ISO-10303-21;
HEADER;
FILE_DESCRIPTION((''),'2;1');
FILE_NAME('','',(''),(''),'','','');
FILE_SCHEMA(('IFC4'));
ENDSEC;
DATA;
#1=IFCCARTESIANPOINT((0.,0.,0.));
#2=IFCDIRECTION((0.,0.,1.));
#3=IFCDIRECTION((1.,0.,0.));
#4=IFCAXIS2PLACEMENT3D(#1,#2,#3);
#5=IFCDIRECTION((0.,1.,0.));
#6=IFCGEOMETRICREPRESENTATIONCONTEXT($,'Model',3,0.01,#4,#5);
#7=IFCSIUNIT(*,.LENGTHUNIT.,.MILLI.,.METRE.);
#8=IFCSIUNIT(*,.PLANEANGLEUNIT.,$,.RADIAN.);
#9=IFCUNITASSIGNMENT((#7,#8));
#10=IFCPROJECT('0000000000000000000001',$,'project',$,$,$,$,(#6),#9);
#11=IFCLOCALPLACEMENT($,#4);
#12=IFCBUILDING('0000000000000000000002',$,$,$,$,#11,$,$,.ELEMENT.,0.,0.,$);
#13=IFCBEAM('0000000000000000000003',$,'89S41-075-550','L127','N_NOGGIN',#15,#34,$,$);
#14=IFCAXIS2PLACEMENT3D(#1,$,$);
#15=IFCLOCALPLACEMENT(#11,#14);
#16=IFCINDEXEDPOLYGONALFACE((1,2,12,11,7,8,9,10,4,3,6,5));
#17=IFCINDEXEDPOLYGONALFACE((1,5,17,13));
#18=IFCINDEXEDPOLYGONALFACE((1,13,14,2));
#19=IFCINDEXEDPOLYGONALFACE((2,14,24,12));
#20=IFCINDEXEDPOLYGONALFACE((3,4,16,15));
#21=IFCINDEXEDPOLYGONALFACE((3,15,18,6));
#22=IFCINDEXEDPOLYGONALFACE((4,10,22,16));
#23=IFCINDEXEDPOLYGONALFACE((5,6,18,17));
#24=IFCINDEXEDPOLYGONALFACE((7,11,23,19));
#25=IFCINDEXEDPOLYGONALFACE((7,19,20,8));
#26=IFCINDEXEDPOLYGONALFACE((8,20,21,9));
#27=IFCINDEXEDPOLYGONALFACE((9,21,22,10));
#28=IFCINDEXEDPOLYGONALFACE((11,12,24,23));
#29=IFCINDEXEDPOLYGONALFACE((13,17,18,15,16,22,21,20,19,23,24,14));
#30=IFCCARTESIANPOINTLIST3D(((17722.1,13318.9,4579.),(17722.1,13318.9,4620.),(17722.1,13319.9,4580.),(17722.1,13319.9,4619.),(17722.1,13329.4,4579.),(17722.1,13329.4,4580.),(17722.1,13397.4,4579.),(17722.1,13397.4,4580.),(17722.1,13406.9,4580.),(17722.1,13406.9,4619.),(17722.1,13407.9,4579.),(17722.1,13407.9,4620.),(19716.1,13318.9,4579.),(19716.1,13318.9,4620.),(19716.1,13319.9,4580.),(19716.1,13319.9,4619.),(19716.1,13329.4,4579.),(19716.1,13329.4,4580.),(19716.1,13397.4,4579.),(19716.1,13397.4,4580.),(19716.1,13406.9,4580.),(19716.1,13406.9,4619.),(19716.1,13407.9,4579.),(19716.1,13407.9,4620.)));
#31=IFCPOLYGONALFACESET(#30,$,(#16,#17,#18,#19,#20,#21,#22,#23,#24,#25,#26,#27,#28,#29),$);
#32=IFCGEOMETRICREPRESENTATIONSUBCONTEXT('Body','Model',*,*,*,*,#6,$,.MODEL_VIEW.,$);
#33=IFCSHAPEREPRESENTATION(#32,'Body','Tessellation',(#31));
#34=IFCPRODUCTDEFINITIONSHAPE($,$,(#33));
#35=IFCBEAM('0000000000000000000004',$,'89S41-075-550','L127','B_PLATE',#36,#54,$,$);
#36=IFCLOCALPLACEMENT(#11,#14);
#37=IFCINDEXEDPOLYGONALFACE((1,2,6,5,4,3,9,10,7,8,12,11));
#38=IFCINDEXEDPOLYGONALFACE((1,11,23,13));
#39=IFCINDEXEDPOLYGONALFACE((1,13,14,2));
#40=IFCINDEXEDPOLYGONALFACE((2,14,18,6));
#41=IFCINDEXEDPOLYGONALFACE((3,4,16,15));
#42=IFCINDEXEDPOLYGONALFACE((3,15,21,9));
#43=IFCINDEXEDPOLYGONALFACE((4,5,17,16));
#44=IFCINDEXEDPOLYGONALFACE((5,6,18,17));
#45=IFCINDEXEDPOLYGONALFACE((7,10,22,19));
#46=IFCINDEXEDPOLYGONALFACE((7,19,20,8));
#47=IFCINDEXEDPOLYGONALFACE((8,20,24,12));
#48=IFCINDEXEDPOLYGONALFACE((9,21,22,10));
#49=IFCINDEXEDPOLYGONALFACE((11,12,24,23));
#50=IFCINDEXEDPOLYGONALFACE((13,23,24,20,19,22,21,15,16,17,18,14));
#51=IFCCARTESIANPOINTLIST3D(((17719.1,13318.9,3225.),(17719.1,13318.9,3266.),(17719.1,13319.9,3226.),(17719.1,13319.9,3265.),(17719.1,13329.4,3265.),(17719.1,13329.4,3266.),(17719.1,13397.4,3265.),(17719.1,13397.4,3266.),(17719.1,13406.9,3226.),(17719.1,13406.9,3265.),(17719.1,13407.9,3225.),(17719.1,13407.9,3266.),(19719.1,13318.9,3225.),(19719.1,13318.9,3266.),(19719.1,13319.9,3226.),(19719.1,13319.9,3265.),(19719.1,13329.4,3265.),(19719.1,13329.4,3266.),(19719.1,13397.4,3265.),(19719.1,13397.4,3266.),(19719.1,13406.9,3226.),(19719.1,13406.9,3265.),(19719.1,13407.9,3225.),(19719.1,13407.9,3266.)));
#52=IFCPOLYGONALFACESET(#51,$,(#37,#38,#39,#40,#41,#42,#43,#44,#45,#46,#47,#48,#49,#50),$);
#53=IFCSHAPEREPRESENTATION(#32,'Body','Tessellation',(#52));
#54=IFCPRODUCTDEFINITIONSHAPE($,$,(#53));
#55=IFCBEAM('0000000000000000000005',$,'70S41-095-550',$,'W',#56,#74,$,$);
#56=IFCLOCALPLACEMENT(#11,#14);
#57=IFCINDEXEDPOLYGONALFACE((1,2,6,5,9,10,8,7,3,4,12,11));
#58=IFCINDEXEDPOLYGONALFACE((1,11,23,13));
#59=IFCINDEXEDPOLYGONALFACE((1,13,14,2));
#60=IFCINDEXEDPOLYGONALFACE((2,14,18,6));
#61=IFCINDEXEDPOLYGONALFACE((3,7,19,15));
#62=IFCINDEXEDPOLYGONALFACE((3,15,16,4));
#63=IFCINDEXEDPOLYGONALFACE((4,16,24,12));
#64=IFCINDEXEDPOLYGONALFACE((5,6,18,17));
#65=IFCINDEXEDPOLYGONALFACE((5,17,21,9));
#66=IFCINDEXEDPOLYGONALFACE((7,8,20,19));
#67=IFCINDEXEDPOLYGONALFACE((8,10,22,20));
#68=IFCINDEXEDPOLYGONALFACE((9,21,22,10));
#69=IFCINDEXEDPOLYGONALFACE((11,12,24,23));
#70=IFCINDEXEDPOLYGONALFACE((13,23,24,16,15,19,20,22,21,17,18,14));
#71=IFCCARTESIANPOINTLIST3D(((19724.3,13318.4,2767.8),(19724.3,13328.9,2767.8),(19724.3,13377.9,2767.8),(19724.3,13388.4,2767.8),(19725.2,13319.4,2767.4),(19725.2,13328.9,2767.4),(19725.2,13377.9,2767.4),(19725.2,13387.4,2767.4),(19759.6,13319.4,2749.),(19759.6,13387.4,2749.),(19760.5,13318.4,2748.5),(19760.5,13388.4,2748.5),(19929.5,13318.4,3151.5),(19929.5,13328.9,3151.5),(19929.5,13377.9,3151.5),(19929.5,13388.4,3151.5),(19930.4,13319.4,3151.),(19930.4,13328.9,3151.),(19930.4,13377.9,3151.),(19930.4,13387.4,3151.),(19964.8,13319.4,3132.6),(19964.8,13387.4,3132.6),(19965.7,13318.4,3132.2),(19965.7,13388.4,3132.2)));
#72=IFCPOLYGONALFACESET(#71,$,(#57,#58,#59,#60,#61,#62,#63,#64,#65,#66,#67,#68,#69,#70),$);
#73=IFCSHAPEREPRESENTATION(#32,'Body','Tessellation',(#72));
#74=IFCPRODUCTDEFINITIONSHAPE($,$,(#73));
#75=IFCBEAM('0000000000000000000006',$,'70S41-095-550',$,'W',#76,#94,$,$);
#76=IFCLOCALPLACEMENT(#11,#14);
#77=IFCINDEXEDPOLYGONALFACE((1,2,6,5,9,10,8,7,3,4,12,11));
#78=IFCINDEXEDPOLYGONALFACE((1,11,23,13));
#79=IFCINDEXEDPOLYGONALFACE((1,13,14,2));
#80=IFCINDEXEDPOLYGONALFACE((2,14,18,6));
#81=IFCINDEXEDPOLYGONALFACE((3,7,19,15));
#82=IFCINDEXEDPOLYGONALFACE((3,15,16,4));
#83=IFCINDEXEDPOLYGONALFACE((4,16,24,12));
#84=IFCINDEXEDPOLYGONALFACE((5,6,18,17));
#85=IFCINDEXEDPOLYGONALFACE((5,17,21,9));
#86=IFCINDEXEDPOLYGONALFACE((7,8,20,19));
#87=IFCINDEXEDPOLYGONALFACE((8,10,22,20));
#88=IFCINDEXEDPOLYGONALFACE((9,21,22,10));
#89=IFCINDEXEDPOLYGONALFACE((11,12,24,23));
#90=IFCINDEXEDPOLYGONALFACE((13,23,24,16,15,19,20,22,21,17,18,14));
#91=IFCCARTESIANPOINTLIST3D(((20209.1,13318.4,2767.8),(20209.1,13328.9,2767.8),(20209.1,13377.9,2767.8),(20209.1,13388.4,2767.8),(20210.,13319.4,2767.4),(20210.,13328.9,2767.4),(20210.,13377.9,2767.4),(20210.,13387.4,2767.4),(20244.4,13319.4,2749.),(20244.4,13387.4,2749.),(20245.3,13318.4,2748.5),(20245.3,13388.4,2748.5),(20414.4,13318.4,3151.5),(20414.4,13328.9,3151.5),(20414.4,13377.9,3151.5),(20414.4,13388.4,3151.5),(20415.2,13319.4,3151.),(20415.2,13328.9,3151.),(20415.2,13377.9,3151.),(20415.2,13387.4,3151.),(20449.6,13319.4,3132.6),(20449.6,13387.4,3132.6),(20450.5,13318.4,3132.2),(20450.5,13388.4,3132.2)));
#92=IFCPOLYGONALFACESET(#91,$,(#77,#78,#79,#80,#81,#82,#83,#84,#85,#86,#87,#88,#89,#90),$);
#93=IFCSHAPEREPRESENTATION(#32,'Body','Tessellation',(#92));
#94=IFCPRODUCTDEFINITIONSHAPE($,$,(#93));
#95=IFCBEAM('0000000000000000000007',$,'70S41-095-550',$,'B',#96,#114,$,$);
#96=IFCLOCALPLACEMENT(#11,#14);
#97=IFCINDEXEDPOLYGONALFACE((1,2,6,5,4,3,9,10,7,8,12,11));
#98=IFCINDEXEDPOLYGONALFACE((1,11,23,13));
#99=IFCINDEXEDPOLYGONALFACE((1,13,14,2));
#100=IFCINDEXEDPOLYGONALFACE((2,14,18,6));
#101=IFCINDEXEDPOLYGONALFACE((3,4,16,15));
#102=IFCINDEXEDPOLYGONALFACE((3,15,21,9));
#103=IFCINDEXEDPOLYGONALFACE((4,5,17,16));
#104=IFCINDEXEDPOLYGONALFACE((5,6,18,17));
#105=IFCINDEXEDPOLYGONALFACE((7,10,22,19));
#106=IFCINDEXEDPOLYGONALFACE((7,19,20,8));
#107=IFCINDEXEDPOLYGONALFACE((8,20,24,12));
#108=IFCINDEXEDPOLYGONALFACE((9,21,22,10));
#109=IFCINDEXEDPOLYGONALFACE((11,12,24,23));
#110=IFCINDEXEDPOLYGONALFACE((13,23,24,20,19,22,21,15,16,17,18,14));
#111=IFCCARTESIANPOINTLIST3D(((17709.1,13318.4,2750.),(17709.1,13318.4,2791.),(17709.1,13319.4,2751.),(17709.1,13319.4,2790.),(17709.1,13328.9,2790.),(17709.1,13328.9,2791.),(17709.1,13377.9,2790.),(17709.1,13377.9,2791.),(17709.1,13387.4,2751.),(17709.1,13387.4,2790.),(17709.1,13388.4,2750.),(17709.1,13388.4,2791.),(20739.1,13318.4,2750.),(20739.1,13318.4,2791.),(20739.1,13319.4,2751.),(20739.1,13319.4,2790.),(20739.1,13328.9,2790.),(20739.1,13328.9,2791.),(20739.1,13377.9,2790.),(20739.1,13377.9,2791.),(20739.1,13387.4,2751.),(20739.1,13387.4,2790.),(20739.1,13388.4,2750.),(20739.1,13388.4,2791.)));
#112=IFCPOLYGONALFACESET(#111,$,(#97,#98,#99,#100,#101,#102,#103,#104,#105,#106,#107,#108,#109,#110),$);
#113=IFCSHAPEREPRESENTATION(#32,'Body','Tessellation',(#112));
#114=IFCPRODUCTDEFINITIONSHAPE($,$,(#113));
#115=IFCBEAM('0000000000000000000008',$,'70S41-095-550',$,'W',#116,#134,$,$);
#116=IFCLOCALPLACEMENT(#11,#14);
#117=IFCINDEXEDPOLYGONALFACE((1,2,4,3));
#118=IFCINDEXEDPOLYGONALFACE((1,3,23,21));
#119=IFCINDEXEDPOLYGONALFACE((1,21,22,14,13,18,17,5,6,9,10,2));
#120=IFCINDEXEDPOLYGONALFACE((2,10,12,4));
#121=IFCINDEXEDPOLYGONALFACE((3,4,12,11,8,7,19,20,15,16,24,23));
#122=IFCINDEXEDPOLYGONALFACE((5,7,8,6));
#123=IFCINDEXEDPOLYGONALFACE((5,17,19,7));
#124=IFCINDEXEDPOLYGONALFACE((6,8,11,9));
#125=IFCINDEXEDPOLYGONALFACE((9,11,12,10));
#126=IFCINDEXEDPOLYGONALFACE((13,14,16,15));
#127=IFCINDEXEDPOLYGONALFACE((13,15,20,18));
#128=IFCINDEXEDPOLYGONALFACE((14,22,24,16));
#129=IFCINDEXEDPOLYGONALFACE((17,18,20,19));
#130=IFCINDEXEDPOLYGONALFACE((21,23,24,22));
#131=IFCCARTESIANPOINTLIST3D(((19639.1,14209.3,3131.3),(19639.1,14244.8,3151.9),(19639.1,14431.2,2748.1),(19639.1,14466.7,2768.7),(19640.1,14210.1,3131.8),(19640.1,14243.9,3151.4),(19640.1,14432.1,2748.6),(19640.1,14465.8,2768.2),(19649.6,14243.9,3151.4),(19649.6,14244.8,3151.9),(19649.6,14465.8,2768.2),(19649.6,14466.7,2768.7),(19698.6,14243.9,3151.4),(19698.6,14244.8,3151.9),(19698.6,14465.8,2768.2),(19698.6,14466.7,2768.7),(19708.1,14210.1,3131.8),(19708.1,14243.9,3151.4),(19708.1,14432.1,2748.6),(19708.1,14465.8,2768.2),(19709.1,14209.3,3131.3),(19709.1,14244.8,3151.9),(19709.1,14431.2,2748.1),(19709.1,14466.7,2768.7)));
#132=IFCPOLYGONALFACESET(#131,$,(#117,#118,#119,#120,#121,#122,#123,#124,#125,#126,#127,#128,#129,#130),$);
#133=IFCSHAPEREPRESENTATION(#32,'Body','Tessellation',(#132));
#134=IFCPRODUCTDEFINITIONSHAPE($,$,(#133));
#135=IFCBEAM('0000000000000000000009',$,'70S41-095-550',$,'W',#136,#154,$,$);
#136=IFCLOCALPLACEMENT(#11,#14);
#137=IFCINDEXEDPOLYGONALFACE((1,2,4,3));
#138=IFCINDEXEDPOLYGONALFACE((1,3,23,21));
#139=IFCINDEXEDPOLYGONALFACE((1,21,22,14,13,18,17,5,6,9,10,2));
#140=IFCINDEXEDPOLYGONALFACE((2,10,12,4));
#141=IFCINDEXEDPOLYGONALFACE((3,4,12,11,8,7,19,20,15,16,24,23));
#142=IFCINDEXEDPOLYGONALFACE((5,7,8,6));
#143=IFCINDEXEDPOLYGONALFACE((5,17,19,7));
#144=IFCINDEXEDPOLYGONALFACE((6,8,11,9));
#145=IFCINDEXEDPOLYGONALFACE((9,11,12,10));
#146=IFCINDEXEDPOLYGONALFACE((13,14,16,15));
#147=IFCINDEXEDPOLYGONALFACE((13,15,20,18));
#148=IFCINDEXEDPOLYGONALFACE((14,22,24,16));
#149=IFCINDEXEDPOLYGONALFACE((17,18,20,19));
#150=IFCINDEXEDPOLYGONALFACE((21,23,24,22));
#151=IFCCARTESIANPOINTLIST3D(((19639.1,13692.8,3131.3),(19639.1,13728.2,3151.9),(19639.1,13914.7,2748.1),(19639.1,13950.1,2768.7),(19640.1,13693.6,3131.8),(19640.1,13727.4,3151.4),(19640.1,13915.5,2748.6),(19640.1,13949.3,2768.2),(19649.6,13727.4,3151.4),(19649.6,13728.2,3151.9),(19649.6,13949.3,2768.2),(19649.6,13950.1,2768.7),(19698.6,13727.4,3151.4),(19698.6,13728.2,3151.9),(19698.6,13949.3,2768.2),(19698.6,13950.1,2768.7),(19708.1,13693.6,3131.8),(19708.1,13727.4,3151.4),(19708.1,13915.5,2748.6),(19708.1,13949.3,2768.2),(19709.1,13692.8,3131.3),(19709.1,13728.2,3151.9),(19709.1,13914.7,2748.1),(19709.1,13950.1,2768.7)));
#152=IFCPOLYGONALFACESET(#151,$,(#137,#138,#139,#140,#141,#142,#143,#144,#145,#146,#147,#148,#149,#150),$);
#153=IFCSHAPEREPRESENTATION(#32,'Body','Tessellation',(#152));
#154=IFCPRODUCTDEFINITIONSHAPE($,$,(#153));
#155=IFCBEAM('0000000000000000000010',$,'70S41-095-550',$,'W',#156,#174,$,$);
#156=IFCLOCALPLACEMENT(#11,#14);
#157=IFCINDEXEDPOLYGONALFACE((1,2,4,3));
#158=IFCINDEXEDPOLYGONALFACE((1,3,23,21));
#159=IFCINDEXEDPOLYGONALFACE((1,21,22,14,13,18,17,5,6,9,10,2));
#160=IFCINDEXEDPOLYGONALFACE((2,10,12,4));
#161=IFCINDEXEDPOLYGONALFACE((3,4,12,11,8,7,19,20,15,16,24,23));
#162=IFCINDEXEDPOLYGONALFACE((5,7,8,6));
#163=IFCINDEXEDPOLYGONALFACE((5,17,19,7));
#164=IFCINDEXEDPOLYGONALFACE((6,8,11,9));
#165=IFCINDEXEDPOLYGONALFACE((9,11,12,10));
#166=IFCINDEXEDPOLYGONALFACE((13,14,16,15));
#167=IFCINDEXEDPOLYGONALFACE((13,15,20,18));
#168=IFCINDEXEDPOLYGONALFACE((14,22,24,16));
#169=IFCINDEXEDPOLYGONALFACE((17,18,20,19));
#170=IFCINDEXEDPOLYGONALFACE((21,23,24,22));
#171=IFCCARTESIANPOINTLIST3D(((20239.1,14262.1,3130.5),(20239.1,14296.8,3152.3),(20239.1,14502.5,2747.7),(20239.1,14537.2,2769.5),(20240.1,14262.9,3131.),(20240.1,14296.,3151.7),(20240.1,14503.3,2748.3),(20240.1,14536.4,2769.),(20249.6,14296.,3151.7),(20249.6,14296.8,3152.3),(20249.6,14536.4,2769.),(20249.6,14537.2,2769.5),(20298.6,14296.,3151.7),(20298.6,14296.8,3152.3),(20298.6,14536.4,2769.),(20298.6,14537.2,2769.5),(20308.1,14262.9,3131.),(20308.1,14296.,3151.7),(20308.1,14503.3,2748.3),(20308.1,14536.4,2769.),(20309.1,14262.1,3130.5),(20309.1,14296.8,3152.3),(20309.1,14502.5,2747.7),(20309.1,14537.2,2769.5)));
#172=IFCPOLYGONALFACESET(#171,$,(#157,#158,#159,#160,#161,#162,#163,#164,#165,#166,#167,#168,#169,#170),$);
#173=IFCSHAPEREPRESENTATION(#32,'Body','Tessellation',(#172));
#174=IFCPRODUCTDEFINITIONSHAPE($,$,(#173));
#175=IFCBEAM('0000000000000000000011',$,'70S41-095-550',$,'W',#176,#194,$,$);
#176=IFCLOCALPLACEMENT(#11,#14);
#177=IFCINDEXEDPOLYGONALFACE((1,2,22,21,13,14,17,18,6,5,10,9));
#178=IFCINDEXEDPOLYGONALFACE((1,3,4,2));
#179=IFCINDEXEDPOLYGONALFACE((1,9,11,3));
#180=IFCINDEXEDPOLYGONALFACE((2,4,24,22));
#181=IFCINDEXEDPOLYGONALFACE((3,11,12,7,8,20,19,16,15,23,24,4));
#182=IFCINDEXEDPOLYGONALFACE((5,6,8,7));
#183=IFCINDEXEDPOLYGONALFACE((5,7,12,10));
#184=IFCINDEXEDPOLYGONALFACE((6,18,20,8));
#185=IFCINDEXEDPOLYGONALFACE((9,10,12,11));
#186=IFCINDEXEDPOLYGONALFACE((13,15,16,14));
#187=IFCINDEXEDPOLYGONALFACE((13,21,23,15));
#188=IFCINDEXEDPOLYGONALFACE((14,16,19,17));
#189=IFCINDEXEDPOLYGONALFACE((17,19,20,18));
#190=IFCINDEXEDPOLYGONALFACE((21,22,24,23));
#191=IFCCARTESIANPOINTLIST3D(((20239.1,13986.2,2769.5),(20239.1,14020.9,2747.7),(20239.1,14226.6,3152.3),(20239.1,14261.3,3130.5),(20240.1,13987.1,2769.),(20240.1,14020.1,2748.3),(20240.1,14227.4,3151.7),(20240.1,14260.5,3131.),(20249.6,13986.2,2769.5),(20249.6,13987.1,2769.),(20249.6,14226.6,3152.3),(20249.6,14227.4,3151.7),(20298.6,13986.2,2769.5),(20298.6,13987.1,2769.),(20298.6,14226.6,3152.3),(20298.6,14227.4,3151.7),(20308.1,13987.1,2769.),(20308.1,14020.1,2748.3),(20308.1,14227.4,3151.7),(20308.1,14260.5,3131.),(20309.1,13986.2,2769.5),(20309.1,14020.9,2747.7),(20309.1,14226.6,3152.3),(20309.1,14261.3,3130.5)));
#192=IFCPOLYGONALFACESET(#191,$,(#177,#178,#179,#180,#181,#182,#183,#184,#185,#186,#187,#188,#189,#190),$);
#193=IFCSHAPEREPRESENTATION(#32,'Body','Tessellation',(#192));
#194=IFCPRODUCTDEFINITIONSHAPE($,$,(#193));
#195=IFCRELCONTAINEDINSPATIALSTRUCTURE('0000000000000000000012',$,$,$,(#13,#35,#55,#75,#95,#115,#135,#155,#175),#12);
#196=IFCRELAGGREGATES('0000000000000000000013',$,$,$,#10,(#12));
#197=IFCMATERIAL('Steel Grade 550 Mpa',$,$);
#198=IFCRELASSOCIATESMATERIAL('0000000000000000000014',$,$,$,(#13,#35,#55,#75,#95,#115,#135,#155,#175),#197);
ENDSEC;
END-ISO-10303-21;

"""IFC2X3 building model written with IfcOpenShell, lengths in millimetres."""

from ifc_helpers import new_model, si_unit, direction, frame, origin, origin_with_axes, origin_2d_with_axis, place, context, subcontext, project, spatial, c_section, extrude, source, transform, mapped, material, element, save


model = new_model("IFC2X3")

# Units and contexts
model_context = context("Model", 3, precision=0.01, world=origin_with_axes(), true_north=direction((0.0, 1.0, 0.0)))
body_context = subcontext(model_context, "Body", "Model", "MODEL_VIEW")
ifc_project = project(units=[si_unit("LENGTHUNIT", "METRE", prefix="MILLI"), si_unit("PLANEANGLEUNIT", "RADIAN")], contexts=[model_context])

# Building
building_placement = place(None, origin_with_axes())
building = spatial("IfcBuilding", under=ifc_project, at=building_placement, CompositionType="ELEMENT", ElevationOfRefHeight=0.0, ElevationOfTerrain=0.0)

# Shared definitions
ifc_material = material(Name="Steel Grade 550 Mpa")

# Beams
shared_shape_1 = source(origin(), body_context, "Body", "SweptSolid", [
    extrude(c_section(Depth=89.0, Width=41.0, WallThickness=1.0, Girth=10.5, at=origin_2d_with_axis()), origin_with_axes(), (0.0, 0.0, 1.0), 1994.0),
])
beam_1_placement = place(None, frame((19716.1, 13363.4, 4599.5), z_axis=(-1.0, 0.0, 0.0), x_axis=(0.0, 0.0, -1.0)))
element("IfcBeam", 1, at=beam_1_placement, inside=building, material=ifc_material, Name="89S41-075-550", Description="L127", ObjectType="N_NOGGIN", context=body_context, shape_type="MappedRepresentation", body=[
    mapped(shared_shape_1, transform((0.0, 0.0, 0.0), scale=1.0)),
])
shared_shape_2 = source(origin(), body_context, "Body", "SweptSolid", [
    extrude(c_section(Depth=89.0, Width=41.0, WallThickness=1.0, Girth=10.5, at=origin_2d_with_axis()), origin_with_axes(), (0.0, 0.0, 1.0), 2000.0),
])
beam_2_placement = place(None, frame((19719.1, 13363.4, 3245.5), z_axis=(-1.0, 0.0, 0.0), x_axis=(0.0, 0.0, 1.0)))
element("IfcBeam", 2, at=beam_2_placement, inside=building, material=ifc_material, Name="89S41-075-550", Description="L127", ObjectType="B_PLATE", context=body_context, shape_type="MappedRepresentation", body=[
    mapped(shared_shape_2, transform((0.0, 0.0, 0.0), scale=1.0)),
])
shared_shape_3 = source(origin(), body_context, "Body", "SweptSolid", [
    extrude(c_section(Depth=70.0, Width=41.0, WallThickness=1.0, Girth=10.5, at=origin_2d_with_axis()), origin_with_axes(), (0.0, 0.0, 1.0), 435.1),
])
beam_3_placement = place(None, frame((19947.6, 13353.4, 3141.8), z_axis=(-0.471634, 0.0, -0.881794), x_axis=(-0.881794, 0.0, 0.471634)))
element("IfcBeam", 3, at=beam_3_placement, inside=building, material=ifc_material, Name="70S41-095-550", ObjectType="W", context=body_context, shape_type="MappedRepresentation", body=[
    mapped(shared_shape_3, transform((0.0, 0.0, 0.0), scale=1.0)),
])
shared_shape_4 = source(origin(), body_context, "Body", "SweptSolid", [
    extrude(c_section(Depth=70.0, Width=41.0, WallThickness=1.0, Girth=10.5, at=origin_2d_with_axis()), origin_with_axes(), (0.0, 0.0, 1.0), 435.1),
])
beam_4_placement = place(None, frame((20432.4, 13353.4, 3141.8), z_axis=(-0.471634, 0.0, -0.881794), x_axis=(-0.881794, 0.0, 0.471634)))
element("IfcBeam", 4, at=beam_4_placement, inside=building, material=ifc_material, Name="70S41-095-550", ObjectType="W", context=body_context, shape_type="MappedRepresentation", body=[
    mapped(shared_shape_4, transform((0.0, 0.0, 0.0), scale=1.0)),
])
shared_shape_5 = source(origin(), body_context, "Body", "SweptSolid", [
    extrude(c_section(Depth=70.0, Width=41.0, WallThickness=1.0, Girth=10.5, at=origin_2d_with_axis()), origin_with_axes(), (0.0, 0.0, 1.0), 3030.0),
])
beam_5_placement = place(None, frame((20739.1, 13353.4, 2770.5), z_axis=(-1.0, 0.0, 0.0), x_axis=(0.0, 0.0, 1.0)))
element("IfcBeam", 5, at=beam_5_placement, inside=building, material=ifc_material, Name="70S41-095-550", ObjectType="B", context=body_context, shape_type="MappedRepresentation", body=[
    mapped(shared_shape_5, transform((0.0, 0.0, 0.0), scale=1.0)),
])
shared_shape_6 = source(origin(), body_context, "Body", "SweptSolid", [
    extrude(c_section(Depth=70.0, Width=41.0, WallThickness=1.0, Girth=10.5, at=origin_2d_with_axis()), origin_with_axes(), (0.0, 0.0, 1.0), 442.8),
])
beam_6_placement = place(None, frame((19674.1, 14227.0, 3141.6), z_axis=(0.0, 0.501095, -0.865392), x_axis=(0.0, 0.865392, 0.501095)))
element("IfcBeam", 6, at=beam_6_placement, inside=building, material=ifc_material, Name="70S41-095-550", ObjectType="W", context=body_context, shape_type="MappedRepresentation", body=[
    mapped(shared_shape_6, transform((0.0, 0.0, 0.0), scale=1.0)),
])
shared_shape_7 = source(origin(), body_context, "Body", "SweptSolid", [
    extrude(c_section(Depth=70.0, Width=41.0, WallThickness=1.0, Girth=10.5, at=origin_2d_with_axis()), origin_with_axes(), (0.0, 0.0, 1.0), 442.8),
])
beam_7_placement = place(None, frame((19674.1, 13710.5, 3141.6), z_axis=(0.0, 0.501095, -0.865392), x_axis=(0.0, 0.865392, 0.501095)))
element("IfcBeam", 7, at=beam_7_placement, inside=building, material=ifc_material, Name="70S41-095-550", ObjectType="W", context=body_context, shape_type="MappedRepresentation", body=[
    mapped(shared_shape_7, transform((0.0, 0.0, 0.0), scale=1.0)),
])
shared_shape_8 = source(origin(), body_context, "Body", "SweptSolid", [
    extrude(c_section(Depth=70.0, Width=41.0, WallThickness=1.0, Girth=10.5, at=origin_2d_with_axis()), origin_with_axes(), (0.0, 0.0, 1.0), 451.9),
])
beam_8_placement = place(None, frame((20274.1, 14279.5, 3141.4), z_axis=(0.0, 0.531898, -0.846809), x_axis=(0.0, 0.846809, 0.531898)))
element("IfcBeam", 8, at=beam_8_placement, inside=building, material=ifc_material, Name="70S41-095-550", ObjectType="W", context=body_context, shape_type="MappedRepresentation", body=[
    mapped(shared_shape_8, transform((0.0, 0.0, 0.0), scale=1.0)),
])
shared_shape_9 = source(origin(), body_context, "Body", "SweptSolid", [
    extrude(c_section(Depth=70.0, Width=41.0, WallThickness=1.0, Girth=10.5, at=origin_2d_with_axis()), origin_with_axes(), (0.0, 0.0, 1.0), 451.9),
])
beam_9_placement = place(None, frame((20274.1, 14003.6, 2758.6), z_axis=(0.0, 0.531898, 0.846809), x_axis=(0.0, -0.846809, 0.531898)))
element("IfcBeam", 9, at=beam_9_placement, inside=building, material=ifc_material, Name="70S41-095-550", ObjectType="W", context=body_context, shape_type="MappedRepresentation", body=[
    mapped(shared_shape_9, transform((0.0, 0.0, 0.0), scale=1.0)),
])

save(model, "model.ifc")
